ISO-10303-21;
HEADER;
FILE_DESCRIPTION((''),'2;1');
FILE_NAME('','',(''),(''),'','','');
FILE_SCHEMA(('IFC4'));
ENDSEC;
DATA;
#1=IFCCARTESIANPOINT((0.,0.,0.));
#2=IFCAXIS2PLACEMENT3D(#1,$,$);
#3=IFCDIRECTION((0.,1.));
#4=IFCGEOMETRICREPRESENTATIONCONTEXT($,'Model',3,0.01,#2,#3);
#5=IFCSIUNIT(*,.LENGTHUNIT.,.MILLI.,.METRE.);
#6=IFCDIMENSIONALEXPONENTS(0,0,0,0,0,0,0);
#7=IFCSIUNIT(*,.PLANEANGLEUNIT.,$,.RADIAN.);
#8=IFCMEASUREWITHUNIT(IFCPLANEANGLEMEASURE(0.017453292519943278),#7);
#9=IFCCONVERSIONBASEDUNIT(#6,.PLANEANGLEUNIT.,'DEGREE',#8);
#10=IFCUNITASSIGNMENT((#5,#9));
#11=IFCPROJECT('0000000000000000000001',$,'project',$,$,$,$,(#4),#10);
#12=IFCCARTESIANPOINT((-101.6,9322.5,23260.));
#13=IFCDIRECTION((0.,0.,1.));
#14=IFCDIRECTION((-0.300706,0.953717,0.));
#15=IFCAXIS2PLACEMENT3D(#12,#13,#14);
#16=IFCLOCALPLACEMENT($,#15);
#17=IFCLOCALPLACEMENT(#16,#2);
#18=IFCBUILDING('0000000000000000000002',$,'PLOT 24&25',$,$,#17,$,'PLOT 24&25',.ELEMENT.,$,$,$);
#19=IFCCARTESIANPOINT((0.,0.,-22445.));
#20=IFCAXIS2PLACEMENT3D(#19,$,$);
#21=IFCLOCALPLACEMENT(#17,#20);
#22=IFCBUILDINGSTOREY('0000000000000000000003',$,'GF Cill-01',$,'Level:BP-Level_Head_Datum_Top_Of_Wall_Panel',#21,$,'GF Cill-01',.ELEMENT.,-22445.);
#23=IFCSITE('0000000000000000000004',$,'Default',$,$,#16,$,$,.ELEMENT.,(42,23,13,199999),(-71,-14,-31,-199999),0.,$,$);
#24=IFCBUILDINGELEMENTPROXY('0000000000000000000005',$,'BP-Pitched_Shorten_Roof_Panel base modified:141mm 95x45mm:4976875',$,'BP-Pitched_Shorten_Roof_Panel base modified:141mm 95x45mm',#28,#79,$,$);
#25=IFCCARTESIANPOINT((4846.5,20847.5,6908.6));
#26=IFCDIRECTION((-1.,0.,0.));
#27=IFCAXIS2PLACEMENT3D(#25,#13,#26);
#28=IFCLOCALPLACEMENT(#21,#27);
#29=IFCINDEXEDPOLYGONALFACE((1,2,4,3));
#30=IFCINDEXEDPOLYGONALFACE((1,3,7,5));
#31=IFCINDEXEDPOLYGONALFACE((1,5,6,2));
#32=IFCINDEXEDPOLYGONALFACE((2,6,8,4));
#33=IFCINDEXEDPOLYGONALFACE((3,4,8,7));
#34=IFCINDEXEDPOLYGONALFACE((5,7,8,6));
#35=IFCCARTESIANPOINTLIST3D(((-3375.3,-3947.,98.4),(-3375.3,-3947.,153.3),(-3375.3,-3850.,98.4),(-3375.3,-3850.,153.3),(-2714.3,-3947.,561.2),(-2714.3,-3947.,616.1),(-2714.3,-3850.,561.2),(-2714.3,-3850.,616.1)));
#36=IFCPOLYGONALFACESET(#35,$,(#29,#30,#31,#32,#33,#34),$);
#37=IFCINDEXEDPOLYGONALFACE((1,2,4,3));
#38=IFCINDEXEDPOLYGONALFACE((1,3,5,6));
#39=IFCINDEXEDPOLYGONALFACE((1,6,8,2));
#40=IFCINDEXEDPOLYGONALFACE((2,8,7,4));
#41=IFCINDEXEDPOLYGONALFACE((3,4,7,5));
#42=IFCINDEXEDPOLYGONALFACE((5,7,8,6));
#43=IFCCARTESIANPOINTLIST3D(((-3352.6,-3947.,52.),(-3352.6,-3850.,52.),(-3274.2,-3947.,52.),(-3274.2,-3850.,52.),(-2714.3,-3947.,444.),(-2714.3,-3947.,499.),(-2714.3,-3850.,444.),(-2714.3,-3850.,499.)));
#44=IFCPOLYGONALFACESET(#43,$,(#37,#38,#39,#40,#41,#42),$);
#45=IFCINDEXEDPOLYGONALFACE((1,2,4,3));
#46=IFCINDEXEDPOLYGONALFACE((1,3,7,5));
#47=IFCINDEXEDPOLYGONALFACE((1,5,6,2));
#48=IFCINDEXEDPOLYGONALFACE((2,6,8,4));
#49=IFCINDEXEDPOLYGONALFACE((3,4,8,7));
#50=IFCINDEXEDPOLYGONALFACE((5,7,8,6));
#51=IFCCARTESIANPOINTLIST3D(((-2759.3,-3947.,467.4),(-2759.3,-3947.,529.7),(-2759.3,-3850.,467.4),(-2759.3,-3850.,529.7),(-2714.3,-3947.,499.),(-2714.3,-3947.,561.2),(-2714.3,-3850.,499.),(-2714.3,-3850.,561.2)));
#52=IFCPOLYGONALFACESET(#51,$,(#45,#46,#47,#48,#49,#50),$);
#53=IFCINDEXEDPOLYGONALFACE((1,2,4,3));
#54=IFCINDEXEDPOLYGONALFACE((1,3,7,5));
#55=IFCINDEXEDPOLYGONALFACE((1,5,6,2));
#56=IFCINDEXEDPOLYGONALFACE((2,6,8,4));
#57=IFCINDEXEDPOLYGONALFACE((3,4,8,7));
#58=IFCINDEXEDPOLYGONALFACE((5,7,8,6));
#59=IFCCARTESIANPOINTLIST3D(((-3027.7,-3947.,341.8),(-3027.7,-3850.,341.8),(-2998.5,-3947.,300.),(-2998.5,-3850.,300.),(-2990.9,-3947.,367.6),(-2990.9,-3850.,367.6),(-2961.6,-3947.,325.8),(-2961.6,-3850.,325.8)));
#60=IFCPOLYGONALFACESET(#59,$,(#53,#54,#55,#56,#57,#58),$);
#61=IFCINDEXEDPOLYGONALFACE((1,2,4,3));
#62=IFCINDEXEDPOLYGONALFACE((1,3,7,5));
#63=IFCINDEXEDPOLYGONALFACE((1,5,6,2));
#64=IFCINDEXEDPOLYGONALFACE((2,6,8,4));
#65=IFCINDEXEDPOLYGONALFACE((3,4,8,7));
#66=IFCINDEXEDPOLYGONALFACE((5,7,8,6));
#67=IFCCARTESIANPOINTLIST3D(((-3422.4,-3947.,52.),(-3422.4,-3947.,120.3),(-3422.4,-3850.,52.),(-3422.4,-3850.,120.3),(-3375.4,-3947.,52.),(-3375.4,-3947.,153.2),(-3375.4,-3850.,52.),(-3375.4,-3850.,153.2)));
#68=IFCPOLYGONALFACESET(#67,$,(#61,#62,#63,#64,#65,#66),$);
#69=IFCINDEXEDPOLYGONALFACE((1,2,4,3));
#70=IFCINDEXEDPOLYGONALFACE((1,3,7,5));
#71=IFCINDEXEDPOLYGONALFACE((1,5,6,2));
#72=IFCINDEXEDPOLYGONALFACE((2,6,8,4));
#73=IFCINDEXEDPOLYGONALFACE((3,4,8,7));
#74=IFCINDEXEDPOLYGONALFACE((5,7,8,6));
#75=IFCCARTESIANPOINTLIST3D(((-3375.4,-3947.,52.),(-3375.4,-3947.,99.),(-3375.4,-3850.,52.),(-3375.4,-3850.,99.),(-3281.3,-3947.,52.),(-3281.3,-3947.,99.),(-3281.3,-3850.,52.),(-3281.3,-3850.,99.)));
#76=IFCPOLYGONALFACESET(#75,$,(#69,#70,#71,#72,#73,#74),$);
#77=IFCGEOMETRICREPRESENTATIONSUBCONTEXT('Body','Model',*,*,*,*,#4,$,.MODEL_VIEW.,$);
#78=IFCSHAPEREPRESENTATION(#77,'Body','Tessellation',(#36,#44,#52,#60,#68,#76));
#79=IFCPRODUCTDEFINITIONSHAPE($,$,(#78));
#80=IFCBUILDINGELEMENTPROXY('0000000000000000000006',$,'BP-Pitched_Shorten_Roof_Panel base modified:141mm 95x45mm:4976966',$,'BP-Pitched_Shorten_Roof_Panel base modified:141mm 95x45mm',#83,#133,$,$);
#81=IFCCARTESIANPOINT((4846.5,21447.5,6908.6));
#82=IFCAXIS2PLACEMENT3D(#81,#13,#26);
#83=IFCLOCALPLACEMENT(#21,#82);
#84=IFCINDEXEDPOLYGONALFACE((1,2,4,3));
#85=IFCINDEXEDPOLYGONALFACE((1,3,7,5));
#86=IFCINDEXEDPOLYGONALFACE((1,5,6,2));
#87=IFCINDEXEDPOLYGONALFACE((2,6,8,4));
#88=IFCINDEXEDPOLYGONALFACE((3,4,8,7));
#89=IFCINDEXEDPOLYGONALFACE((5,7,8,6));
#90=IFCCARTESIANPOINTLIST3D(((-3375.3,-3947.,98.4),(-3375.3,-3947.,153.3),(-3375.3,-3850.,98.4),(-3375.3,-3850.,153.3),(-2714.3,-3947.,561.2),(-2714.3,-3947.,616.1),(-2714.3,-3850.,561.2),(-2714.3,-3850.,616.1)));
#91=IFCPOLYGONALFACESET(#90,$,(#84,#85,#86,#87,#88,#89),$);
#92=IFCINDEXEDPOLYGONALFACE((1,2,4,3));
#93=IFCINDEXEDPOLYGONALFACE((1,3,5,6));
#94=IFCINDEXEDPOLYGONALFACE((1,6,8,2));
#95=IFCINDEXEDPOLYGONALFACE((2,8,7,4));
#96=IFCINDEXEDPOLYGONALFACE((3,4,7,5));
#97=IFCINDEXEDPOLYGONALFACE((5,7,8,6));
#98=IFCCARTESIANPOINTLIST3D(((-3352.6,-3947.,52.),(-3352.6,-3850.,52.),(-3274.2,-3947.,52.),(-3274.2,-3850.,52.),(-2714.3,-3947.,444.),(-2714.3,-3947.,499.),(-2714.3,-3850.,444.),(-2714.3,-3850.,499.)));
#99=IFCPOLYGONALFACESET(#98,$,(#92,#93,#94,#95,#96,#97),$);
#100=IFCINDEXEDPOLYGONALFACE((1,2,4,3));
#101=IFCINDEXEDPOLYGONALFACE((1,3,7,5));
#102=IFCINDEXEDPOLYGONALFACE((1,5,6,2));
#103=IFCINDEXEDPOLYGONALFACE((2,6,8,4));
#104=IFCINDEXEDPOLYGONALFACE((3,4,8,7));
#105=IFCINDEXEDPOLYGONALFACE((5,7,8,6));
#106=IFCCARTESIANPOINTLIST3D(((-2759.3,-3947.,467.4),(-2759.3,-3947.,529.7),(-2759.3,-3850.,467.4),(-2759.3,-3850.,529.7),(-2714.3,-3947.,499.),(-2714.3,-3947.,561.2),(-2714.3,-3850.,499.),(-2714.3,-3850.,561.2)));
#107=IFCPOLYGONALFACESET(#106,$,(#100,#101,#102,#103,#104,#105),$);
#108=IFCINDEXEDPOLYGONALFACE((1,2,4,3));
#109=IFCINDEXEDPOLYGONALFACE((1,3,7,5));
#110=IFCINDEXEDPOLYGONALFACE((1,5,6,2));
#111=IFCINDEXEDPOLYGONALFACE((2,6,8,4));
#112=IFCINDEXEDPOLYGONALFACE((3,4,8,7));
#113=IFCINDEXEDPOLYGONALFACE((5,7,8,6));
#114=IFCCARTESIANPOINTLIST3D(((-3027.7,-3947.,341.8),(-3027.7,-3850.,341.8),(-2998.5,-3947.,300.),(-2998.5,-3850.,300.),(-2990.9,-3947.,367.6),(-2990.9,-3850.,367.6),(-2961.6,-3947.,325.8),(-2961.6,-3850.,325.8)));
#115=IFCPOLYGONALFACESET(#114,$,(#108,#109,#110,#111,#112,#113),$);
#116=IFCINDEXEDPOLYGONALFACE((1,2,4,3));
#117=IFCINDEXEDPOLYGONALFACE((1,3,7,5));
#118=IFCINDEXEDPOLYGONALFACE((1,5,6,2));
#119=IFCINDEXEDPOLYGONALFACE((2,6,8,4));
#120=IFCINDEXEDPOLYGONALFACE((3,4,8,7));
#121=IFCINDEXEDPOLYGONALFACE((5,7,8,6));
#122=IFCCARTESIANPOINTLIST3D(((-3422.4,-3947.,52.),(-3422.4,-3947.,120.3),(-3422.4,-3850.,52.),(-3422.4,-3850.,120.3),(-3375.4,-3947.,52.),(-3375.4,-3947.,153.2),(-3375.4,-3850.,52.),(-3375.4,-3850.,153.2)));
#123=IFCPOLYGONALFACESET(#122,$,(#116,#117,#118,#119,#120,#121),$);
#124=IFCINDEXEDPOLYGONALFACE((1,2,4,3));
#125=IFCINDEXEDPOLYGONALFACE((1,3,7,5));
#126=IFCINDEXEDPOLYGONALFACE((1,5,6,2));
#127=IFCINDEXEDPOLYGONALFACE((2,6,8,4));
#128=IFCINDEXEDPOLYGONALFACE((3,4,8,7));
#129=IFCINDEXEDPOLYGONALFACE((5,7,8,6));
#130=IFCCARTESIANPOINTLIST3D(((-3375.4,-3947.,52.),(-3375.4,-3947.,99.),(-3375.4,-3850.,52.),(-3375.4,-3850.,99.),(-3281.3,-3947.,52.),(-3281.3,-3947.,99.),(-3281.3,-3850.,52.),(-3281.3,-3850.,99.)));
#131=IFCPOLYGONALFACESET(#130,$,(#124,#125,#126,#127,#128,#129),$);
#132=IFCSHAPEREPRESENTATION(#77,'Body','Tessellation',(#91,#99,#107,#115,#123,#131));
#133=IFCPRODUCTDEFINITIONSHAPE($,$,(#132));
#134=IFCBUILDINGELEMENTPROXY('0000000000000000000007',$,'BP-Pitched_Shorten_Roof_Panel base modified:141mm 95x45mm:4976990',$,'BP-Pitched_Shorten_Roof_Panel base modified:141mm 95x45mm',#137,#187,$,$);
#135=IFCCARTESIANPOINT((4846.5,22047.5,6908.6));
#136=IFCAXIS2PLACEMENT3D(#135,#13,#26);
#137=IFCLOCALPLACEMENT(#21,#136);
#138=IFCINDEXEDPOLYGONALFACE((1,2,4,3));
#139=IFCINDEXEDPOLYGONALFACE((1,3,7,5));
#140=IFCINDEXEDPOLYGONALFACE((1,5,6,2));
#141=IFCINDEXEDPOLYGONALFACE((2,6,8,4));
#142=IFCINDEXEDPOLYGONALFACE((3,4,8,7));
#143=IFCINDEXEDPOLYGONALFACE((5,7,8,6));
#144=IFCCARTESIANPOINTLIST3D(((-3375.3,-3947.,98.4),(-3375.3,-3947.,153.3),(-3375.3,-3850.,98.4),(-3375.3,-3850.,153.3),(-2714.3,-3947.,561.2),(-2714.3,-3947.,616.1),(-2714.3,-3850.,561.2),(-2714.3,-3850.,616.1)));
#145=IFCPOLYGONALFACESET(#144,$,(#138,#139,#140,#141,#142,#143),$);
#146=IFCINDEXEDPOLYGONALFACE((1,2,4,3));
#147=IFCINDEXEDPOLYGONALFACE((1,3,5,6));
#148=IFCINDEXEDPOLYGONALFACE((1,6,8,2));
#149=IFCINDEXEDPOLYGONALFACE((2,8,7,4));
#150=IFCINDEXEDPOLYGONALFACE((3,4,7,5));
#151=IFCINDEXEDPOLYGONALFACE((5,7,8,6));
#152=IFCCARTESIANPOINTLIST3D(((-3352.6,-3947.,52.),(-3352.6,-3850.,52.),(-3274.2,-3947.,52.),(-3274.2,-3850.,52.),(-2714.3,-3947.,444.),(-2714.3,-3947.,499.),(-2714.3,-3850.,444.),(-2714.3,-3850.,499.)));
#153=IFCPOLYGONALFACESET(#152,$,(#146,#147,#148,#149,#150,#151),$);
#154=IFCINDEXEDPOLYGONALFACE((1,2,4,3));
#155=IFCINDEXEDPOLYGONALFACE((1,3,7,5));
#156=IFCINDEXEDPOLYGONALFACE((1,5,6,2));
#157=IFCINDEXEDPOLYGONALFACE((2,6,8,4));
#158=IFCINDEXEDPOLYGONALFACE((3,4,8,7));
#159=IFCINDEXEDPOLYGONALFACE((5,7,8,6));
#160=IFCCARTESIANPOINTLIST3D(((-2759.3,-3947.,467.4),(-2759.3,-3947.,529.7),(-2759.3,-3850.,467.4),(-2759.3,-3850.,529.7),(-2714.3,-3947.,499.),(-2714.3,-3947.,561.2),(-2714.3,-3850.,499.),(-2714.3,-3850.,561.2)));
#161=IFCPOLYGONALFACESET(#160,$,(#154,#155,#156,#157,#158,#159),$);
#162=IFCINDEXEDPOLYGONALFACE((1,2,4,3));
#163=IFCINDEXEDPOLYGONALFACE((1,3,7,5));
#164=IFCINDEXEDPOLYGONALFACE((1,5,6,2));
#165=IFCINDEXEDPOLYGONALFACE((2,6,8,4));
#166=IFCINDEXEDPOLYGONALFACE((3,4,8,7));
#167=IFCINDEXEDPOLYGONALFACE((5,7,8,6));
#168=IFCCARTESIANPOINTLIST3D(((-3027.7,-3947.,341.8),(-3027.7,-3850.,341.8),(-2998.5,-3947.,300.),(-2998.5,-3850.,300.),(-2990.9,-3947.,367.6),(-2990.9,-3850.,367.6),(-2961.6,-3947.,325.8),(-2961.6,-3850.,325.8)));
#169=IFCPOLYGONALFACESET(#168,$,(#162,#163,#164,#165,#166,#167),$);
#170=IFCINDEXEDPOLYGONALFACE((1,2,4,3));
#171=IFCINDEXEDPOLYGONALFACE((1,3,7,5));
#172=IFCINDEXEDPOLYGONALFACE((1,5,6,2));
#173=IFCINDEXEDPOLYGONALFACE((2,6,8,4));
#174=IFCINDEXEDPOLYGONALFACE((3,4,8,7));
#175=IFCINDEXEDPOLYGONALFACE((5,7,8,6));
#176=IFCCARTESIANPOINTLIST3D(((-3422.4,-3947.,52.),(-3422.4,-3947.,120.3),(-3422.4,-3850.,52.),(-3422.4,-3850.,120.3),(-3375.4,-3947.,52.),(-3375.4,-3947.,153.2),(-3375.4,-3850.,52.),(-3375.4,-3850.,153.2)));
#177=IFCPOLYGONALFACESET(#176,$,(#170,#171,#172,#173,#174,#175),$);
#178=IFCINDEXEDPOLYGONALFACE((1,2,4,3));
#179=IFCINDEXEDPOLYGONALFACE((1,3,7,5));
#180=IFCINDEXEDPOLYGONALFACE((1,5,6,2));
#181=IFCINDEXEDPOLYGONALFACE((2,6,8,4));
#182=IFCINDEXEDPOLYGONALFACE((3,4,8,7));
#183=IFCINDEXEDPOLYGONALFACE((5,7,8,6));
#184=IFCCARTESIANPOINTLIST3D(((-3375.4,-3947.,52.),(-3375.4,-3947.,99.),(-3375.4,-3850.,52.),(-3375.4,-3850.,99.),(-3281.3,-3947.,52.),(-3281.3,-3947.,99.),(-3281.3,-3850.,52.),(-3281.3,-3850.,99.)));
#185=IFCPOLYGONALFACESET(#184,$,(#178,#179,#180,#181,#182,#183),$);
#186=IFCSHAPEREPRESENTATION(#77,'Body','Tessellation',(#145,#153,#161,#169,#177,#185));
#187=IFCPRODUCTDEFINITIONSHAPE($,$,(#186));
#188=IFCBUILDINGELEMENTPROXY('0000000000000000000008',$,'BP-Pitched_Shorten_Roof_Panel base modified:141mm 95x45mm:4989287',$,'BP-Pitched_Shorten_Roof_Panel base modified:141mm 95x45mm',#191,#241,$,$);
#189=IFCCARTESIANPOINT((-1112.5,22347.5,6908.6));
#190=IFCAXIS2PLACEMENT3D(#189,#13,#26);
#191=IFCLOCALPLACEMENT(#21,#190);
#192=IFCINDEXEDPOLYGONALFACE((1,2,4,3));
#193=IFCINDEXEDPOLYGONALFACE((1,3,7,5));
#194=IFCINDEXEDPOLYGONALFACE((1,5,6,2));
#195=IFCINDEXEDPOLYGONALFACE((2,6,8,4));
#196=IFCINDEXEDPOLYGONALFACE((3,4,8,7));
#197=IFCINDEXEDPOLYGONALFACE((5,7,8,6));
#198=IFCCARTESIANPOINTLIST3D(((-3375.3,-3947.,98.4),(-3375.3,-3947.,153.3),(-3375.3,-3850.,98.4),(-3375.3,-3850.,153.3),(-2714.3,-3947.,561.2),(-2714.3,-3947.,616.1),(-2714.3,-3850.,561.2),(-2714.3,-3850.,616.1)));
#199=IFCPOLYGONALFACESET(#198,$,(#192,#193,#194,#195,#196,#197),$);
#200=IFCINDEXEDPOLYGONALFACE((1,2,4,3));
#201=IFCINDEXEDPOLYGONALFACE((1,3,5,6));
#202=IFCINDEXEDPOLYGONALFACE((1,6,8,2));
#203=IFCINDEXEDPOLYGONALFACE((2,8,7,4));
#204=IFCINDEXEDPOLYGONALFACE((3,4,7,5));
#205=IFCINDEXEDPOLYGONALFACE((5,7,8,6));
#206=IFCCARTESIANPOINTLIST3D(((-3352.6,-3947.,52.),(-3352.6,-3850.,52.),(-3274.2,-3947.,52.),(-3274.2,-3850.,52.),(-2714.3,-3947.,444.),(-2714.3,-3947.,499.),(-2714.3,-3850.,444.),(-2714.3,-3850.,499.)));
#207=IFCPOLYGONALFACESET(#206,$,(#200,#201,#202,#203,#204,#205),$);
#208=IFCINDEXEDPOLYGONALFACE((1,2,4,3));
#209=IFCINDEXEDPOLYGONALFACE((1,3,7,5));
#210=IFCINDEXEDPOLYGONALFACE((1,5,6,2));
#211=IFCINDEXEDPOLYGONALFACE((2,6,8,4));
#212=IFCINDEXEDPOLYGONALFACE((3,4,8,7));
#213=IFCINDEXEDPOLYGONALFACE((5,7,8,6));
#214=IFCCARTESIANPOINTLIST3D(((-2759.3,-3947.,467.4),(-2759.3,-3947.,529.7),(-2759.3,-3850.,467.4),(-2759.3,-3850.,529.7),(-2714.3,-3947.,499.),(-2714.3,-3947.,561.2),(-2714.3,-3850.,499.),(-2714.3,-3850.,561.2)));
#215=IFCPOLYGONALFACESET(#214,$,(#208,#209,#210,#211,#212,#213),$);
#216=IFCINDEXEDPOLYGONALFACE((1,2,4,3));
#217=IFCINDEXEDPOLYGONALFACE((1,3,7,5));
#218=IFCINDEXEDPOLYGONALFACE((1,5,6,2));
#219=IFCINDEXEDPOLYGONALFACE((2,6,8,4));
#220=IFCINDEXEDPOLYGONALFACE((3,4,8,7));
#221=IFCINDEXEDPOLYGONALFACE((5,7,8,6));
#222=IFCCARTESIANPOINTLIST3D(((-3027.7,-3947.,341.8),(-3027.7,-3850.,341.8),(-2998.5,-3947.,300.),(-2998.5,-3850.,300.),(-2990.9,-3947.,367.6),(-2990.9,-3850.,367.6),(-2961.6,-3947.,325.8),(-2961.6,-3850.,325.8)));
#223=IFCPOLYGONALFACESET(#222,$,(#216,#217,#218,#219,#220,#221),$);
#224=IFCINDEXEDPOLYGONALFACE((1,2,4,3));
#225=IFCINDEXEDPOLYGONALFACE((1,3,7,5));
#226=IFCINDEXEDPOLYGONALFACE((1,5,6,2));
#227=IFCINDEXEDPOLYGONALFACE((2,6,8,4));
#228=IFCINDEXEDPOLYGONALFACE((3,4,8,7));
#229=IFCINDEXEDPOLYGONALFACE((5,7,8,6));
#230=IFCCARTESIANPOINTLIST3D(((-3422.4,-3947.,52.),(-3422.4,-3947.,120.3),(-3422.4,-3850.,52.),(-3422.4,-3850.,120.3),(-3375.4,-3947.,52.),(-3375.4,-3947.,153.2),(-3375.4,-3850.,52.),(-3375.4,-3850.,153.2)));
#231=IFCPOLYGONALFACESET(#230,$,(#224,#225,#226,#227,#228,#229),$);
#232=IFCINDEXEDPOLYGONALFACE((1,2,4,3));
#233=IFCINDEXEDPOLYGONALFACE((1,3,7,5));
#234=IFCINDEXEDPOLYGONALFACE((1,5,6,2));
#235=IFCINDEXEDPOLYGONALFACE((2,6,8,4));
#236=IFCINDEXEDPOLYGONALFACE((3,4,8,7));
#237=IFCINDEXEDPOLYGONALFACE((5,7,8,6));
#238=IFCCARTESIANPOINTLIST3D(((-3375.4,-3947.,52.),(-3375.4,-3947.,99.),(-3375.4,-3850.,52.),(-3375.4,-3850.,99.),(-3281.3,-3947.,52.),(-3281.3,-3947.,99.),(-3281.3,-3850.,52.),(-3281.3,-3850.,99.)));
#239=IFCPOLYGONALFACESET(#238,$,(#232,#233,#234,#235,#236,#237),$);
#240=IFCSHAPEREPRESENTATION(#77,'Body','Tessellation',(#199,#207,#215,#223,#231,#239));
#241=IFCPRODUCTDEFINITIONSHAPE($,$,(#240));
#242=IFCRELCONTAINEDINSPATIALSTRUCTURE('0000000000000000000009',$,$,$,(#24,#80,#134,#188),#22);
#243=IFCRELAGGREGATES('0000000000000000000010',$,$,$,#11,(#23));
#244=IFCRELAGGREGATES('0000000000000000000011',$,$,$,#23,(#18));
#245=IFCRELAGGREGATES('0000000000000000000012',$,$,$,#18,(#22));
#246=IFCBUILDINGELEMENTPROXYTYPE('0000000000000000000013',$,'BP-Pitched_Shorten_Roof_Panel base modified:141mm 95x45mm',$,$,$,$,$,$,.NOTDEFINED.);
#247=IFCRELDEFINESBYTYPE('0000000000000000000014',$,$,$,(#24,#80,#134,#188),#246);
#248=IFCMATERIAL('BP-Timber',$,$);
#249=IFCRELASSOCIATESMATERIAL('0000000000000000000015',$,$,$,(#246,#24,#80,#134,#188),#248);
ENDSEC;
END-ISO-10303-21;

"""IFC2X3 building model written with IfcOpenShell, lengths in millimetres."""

from ifc_helpers import new_model, entity, si_unit, converted_unit, direction, frame, frame_2d, origin, origin_2d_with_axis, place, context, subcontext, project, spatial, polyline, rectangle, outline, extrude, source, transform, mapped, material, type_object, type_shapes, element, save


model = new_model("IFC2X3")

# Units and contexts
model_context = context("Model", 3, precision=0.01, world=origin(), true_north=direction((0.0, 1.0)))
body_context = subcontext(model_context, "Body", "Model", "MODEL_VIEW")
ifc_project = project(units=[si_unit("LENGTHUNIT", "METRE", prefix="MILLI"), converted_unit("PLANEANGLEUNIT", "DEGREE", entity("IfcPlaneAngleMeasure", 0.017453292519943278), si_unit("PLANEANGLEUNIT", "RADIAN"), dimensions=[0, 0, 0, 0, 0, 0, 0])], contexts=[model_context])

# Site, building, storey
site_placement = place(None, frame((-101.6, 9322.5, 23260.0), z_axis=(0.0, 0.0, 1.0), x_axis=(-0.300706, 0.953717, 0.0)))
site = spatial("IfcSite", under=ifc_project, at=site_placement, Name="Default", CompositionType="ELEMENT", RefLatitude=(42, 23, 13, 199999), RefLongitude=(-71, -14, -31, -199999), RefElevation=0.0)
building_placement = place(site_placement, origin())
building = spatial("IfcBuilding", under=site, at=building_placement, Name="PLOT 24&25", LongName="PLOT 24&25", CompositionType="ELEMENT")
storey_placement = place(building_placement, frame((0.0, 0.0, -22445.0)))
storey = spatial("IfcBuildingStorey", under=building, at=storey_placement, Name="GF Cill-01", ObjectType="Level:BP-Level_Head_Datum_Top_Of_Wall_Panel", LongName="GF Cill-01", CompositionType="ELEMENT", Elevation=-22445.0)

# Shared definitions
ifc_material_1 = material(Name="BP-Timber")

# Building element proxies
building_element_proxy_type_1 = type_object("IfcBuildingElementProxyType", Name="BP-Pitched_Shorten_Roof_Panel base modified:141mm 95x45mm", PredefinedType="NOTDEFINED", material=ifc_material_1)
shared_shape_1 = source(origin(), body_context, "Body", "SweptSolid", [
    extrude(outline(polyline([(-258.9, -330.5), (-204.0, -330.5), (258.9, 330.5), (204.0, 330.5), (-258.9, -330.5)])), frame((-3044.8, -3947.0, 357.3), z_axis=(0.0, 1.0, 0.0), x_axis=(0.0, 0.0, -1.0)), (0.0, 0.0, 1.0), 97.0),
    extrude(outline(polyline([(-237.2, -299.5), (-182.3, -299.5), (209.7, 260.3), (209.7, 338.8), (-237.2, -299.5)])), frame((-3013.9, -3947.0, 261.7), z_axis=(0.0, 1.0, 0.0), x_axis=(0.0, 0.0, -1.0)), (0.0, 0.0, 1.0), 97.0),
    extrude(outline(polyline([(-9.6, -25.5), (45.3, -25.5), (9.6, 25.5), (-45.3, 25.5), (-9.6, -25.5)])), frame((-2736.8, -3947.0, 514.3), z_axis=(0.0, 1.0, 0.0), x_axis=(0.819152, 0.0, 0.573576)), (0.0, 0.0, 1.0), 97.0),
    extrude(rectangle(XDim=51.0, YDim=45.0, at=origin_2d_with_axis()), frame((-2994.7, -3947.0, 333.8), z_axis=(0.0, 1.0, 0.0), x_axis=(0.573576, 0.0, -0.819152)), (0.0, 0.0, 1.0), 97.0),
    extrude(outline(polyline([(-58.9, -23.5), (42.4, -23.5), (42.4, 23.5), (-25.9, 23.5), (-58.9, -23.5)])), frame((-3398.9, -3947.0, 94.4), z_axis=(0.0, 1.0, 0.0), x_axis=(0.0, 0.0, -1.0)), (0.0, 0.0, 1.0), 97.0),
    extrude(rectangle(XDim=94.1, YDim=97.0, at=frame_2d((0.0, 0.0), x_axis=(1.0, 0.0))), frame((-3328.4, -3898.5, 52.0), z_axis=(0.0, 0.0, 1.0), x_axis=(-1.0, 0.0, 0.0)), (0.0, 0.0, 1.0), 47.0),
])
type_shapes(building_element_proxy_type_1, [shared_shape_1])
for number, where, z_axis, x_axis, name in (
    (1, (4846.5, 20847.5, 6908.6), (0.0, 0.0, 1.0), (-1.0, 0.0, 0.0), "BP-Pitched_Shorten_Roof_Panel base modified:141mm 95x45mm:4976875"),
    (2, (4846.5, 21447.5, 6908.6), (0.0, 0.0, 1.0), (-1.0, 0.0, 0.0), "BP-Pitched_Shorten_Roof_Panel base modified:141mm 95x45mm:4976966"),
    (3, (4846.5, 22047.5, 6908.6), (0.0, 0.0, 1.0), (-1.0, 0.0, 0.0), "BP-Pitched_Shorten_Roof_Panel base modified:141mm 95x45mm:4976990"),
    (4, (-1112.5, 22347.5, 6908.6), (0.0, 0.0, 1.0), (-1.0, 0.0, 0.0), "BP-Pitched_Shorten_Roof_Panel base modified:141mm 95x45mm:4989287"),
):
    element("IfcBuildingElementProxy", number, at=place(storey_placement, frame(where, z_axis=z_axis, x_axis=x_axis)), inside=storey, type_object=building_element_proxy_type_1, material=ifc_material_1, Name=name, ObjectType="BP-Pitched_Shorten_Roof_Panel base modified:141mm 95x45mm", context=body_context, shape_type="MappedRepresentation", body=[
        mapped(shared_shape_1, transform((0.0, 0.0, 0.0), scale=1.0)),
    ])

save(model, "model.ifc")
